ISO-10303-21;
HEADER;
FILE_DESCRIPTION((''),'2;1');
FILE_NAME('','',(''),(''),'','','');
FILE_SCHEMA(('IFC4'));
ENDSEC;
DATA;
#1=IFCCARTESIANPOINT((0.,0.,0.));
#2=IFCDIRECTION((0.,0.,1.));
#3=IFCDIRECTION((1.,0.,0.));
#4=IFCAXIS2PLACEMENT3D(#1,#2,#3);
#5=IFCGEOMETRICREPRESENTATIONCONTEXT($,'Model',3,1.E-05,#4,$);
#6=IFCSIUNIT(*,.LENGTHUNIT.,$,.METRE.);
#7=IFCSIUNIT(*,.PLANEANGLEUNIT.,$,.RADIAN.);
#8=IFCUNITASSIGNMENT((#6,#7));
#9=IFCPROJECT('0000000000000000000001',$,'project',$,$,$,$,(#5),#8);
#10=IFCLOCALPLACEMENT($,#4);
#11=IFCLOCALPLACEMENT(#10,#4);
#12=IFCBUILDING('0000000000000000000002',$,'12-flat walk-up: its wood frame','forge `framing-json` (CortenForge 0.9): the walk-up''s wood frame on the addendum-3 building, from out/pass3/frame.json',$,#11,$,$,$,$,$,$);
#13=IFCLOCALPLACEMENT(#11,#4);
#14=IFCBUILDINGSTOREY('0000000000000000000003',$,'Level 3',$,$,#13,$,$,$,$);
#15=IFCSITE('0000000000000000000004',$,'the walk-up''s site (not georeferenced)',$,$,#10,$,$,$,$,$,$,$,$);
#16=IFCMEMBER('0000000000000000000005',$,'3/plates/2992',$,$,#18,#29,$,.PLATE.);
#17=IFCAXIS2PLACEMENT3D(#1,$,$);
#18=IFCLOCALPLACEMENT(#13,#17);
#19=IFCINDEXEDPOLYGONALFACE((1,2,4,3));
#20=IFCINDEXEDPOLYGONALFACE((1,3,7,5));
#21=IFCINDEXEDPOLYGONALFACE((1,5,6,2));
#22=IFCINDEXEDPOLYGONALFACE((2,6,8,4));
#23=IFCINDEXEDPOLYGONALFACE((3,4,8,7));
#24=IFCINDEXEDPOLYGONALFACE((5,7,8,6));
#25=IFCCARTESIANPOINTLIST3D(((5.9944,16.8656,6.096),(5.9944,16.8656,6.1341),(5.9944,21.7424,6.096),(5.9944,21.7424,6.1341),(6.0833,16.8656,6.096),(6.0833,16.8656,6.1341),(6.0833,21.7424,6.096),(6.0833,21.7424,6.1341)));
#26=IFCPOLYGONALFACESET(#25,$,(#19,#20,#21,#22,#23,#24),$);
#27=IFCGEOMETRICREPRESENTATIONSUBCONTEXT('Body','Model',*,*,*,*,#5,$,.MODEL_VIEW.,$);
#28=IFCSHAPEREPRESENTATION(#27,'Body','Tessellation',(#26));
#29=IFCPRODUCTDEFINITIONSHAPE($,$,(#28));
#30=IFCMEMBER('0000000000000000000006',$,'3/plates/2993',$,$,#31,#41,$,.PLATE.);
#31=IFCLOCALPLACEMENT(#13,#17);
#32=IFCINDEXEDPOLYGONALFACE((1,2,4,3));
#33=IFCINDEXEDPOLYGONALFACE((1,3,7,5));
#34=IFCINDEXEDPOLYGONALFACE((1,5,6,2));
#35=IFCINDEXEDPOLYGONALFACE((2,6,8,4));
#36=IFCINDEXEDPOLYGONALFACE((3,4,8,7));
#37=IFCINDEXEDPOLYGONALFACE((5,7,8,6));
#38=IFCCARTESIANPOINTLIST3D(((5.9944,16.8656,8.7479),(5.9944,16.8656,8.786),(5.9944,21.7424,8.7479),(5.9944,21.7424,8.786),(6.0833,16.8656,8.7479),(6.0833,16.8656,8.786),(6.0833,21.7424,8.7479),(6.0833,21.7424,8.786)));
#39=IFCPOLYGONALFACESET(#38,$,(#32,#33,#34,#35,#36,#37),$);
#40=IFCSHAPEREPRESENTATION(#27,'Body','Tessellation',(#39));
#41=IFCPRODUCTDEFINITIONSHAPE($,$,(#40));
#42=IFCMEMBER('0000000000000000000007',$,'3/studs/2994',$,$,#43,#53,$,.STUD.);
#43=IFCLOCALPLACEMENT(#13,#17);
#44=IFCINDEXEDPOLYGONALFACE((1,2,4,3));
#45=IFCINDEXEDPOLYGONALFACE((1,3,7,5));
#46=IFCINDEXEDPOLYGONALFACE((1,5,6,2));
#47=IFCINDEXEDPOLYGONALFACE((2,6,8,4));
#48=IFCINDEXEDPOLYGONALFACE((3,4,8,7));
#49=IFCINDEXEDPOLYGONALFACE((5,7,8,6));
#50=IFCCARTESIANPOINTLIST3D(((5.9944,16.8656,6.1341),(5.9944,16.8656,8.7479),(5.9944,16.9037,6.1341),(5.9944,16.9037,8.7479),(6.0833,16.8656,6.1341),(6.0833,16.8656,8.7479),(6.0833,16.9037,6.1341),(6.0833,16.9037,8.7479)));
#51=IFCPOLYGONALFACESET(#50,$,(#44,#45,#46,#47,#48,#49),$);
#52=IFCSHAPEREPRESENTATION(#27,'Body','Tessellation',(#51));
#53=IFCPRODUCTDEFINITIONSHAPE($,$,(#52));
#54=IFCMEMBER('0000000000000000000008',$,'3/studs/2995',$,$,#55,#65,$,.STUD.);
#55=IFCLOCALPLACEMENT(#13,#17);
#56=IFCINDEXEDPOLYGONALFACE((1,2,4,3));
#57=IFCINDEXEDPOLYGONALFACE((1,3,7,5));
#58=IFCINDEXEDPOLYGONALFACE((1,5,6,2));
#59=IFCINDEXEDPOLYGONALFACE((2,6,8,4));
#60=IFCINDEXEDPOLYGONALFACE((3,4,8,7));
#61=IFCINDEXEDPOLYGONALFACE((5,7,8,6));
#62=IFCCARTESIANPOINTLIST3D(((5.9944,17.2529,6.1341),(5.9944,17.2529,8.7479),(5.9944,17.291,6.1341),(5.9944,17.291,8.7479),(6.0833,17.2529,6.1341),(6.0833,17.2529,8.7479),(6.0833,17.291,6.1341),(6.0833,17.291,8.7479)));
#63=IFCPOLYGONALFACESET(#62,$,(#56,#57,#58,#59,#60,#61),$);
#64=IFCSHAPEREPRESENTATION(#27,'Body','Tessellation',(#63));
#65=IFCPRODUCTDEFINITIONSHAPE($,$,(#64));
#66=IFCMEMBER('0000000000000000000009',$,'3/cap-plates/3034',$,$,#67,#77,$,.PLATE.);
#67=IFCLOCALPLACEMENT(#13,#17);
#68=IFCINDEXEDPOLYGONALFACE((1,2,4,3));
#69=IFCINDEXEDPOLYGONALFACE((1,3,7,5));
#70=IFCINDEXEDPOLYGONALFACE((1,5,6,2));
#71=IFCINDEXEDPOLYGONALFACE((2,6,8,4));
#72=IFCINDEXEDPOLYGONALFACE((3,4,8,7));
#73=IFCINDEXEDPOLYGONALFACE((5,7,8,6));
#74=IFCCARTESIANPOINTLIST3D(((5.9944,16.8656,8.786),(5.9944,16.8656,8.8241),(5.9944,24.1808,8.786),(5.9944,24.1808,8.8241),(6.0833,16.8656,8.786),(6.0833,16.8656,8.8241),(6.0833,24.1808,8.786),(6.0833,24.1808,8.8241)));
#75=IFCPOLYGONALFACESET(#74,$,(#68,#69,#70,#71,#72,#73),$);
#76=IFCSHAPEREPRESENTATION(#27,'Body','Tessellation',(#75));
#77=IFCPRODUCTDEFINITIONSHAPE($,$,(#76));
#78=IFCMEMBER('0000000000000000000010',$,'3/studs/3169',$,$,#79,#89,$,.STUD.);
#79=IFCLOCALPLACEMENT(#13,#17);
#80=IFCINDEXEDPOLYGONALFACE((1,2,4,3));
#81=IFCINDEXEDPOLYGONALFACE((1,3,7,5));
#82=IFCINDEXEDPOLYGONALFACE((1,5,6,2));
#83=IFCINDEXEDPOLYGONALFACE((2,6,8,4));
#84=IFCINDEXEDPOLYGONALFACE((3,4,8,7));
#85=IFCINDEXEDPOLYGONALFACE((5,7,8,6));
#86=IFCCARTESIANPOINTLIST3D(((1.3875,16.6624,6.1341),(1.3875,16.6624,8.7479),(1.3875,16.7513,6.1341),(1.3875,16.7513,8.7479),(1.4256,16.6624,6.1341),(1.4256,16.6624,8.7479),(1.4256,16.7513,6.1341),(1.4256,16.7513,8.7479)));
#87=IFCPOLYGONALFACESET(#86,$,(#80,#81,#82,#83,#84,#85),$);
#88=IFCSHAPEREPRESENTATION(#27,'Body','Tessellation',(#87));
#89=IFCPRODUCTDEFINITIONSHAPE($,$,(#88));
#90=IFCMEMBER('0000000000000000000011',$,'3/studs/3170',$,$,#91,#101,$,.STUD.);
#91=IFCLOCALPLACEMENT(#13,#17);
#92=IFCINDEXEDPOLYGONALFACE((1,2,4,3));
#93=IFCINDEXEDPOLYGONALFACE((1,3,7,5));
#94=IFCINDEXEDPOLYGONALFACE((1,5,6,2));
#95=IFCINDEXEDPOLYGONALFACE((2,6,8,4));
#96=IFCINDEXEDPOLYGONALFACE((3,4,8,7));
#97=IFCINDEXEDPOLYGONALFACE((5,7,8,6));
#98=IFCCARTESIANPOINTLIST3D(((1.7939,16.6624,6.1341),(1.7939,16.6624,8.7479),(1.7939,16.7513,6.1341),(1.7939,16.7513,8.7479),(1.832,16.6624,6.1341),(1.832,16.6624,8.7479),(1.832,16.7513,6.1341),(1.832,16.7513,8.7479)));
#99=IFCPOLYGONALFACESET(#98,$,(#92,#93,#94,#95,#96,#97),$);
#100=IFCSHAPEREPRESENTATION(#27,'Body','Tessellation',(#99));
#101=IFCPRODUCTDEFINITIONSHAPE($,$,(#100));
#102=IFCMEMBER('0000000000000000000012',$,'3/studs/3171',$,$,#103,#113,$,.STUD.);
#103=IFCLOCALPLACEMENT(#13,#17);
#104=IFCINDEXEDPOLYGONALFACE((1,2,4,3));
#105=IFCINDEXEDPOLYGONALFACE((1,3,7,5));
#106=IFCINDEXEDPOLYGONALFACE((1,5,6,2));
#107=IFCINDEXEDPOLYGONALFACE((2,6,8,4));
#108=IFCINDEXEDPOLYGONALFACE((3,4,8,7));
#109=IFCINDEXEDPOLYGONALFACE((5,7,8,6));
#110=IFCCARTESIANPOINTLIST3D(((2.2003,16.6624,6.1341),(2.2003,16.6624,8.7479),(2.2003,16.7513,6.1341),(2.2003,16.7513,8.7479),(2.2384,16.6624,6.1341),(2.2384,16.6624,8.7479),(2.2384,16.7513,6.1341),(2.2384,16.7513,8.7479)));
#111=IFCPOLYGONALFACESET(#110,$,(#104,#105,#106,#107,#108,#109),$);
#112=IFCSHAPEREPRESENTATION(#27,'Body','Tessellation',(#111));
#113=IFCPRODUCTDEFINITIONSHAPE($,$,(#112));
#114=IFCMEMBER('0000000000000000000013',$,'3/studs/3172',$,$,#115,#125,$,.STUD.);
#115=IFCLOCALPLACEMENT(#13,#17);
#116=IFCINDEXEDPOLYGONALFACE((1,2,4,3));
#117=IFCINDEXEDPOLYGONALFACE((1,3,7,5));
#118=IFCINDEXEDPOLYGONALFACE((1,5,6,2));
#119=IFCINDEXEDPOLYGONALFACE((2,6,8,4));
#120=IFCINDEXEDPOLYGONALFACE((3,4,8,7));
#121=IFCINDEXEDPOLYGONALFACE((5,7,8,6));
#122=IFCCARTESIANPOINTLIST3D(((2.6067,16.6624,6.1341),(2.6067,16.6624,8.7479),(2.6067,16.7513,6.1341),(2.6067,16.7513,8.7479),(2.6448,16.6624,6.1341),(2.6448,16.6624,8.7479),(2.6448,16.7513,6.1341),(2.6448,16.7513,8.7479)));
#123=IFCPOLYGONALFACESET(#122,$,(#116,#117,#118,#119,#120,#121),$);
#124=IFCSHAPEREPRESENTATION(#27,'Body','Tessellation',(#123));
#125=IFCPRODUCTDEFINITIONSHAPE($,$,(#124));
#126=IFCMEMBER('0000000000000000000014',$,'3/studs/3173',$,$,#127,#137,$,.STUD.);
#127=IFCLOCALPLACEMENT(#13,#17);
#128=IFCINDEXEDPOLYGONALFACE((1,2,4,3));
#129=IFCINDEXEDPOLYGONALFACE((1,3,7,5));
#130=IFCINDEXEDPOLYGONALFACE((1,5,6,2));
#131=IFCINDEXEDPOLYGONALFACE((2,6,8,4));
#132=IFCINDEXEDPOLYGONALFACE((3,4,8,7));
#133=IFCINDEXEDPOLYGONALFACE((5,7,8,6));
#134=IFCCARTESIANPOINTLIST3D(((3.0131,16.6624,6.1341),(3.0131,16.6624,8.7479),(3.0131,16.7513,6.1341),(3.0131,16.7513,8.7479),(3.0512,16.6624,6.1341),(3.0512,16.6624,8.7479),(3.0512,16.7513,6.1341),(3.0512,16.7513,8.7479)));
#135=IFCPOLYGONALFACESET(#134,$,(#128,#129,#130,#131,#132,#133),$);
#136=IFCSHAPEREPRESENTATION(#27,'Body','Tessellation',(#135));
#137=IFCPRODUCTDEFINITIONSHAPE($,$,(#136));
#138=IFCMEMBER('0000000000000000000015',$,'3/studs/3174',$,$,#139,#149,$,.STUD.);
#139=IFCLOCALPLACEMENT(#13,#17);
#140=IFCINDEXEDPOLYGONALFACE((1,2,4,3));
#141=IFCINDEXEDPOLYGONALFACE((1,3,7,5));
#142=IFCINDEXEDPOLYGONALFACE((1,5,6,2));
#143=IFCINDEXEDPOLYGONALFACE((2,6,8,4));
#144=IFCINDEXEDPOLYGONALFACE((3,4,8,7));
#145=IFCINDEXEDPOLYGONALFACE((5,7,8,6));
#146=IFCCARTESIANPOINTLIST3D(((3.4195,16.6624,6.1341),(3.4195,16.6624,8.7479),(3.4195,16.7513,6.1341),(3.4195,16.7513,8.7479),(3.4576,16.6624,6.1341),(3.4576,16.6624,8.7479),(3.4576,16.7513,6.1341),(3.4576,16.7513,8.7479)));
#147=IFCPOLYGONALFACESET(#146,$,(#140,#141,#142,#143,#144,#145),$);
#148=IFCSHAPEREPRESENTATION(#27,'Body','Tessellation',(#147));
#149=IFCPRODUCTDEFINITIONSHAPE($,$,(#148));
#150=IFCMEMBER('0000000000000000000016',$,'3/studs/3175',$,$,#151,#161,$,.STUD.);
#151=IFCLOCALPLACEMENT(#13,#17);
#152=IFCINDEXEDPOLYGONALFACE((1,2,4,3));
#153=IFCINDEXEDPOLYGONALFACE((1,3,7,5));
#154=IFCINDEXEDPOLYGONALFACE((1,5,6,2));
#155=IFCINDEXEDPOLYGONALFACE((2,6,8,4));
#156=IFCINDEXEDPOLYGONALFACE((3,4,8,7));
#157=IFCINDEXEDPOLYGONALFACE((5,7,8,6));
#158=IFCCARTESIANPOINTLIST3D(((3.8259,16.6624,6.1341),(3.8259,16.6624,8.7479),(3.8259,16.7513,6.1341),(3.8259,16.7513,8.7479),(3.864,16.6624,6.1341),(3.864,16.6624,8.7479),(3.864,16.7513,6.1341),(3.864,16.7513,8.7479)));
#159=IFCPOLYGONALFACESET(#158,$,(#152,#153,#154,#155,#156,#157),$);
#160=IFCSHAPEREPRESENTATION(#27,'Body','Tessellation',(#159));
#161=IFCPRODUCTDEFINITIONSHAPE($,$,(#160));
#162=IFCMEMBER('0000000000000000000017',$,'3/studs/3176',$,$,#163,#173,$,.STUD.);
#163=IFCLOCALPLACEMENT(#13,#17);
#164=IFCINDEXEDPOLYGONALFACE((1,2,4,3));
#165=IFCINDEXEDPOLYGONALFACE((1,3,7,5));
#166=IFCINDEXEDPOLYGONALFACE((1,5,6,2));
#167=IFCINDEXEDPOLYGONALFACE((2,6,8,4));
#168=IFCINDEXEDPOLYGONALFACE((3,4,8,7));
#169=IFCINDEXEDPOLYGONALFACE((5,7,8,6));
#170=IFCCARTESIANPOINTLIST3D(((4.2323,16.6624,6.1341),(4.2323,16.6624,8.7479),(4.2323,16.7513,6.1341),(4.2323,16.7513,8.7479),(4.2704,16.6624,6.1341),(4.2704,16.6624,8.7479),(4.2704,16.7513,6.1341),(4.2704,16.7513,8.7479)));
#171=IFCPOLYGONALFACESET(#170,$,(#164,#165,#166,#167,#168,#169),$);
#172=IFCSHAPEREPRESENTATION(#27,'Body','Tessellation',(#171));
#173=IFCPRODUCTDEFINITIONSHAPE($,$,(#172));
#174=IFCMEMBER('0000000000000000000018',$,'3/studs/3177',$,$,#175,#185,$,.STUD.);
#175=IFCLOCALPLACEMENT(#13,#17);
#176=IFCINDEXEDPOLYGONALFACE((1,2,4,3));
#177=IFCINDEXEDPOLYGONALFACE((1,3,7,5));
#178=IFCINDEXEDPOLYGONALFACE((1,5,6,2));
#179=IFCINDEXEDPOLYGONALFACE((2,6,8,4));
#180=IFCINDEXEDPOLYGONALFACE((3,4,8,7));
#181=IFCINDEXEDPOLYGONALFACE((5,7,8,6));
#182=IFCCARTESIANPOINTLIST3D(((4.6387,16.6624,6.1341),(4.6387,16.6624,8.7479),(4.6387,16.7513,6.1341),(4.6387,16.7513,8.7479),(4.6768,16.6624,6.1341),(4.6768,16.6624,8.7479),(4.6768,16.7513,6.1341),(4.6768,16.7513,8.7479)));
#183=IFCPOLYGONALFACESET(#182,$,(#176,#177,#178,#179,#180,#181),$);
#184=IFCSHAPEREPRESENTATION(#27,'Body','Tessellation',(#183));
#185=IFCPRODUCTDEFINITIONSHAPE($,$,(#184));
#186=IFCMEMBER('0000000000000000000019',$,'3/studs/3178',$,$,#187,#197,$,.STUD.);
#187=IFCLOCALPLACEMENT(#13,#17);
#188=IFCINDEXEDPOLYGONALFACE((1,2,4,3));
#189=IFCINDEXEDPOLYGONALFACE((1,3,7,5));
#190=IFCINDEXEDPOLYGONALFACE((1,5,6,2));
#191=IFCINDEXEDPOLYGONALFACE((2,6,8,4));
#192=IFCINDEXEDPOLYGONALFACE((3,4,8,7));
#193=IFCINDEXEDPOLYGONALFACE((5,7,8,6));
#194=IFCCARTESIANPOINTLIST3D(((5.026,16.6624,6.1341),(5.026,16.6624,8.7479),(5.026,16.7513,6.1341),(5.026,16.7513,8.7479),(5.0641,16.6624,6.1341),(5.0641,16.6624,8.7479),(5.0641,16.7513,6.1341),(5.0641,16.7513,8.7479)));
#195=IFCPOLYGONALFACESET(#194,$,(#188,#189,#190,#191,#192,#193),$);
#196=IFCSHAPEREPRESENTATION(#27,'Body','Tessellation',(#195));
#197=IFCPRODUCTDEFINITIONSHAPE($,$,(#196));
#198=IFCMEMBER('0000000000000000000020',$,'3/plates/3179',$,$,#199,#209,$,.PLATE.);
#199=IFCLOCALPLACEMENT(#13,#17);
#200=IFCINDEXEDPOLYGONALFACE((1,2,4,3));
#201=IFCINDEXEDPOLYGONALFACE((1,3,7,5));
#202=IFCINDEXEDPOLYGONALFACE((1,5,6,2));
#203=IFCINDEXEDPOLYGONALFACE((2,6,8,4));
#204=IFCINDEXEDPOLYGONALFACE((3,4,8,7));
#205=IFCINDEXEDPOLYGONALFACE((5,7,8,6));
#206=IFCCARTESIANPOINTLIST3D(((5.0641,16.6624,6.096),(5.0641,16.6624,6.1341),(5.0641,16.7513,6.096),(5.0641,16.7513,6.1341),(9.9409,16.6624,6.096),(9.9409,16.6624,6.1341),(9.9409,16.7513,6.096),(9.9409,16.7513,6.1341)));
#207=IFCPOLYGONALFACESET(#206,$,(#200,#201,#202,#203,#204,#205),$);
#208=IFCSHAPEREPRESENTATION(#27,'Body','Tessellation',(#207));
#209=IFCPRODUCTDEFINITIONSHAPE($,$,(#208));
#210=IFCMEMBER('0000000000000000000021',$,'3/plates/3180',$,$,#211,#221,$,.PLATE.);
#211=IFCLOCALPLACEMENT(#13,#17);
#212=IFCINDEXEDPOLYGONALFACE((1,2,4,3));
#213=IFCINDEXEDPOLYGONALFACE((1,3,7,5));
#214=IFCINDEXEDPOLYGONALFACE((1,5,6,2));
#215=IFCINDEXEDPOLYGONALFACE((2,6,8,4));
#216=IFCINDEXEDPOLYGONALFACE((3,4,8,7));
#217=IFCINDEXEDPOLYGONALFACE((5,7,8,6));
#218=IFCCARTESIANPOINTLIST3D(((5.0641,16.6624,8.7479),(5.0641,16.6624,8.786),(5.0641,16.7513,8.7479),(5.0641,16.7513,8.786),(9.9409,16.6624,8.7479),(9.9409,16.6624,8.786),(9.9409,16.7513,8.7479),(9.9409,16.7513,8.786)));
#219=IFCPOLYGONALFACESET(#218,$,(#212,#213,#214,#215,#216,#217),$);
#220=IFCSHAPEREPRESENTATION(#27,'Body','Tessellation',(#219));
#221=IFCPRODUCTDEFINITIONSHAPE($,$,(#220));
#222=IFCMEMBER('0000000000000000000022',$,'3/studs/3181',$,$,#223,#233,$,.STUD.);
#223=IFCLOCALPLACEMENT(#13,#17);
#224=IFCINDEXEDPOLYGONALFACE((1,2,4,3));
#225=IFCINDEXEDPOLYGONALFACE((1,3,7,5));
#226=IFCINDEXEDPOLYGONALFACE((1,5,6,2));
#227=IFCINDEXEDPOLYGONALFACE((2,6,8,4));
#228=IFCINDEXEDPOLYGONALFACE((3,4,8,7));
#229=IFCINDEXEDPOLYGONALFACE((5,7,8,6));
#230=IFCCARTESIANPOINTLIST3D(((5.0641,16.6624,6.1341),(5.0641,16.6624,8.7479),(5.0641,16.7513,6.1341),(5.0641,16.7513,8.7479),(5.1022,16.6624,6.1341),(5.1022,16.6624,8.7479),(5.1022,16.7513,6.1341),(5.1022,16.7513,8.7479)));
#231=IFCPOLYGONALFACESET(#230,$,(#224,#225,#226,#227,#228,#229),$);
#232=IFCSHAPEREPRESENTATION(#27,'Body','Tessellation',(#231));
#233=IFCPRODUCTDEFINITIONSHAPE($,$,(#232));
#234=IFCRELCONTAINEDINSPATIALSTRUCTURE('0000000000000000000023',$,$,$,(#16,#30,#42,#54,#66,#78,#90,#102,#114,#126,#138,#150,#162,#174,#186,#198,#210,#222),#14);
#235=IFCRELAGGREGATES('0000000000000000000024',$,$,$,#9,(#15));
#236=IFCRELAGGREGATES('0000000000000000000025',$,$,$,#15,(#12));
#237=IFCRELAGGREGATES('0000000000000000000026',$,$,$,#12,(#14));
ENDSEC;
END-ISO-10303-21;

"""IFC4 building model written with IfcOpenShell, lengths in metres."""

from ifc_helpers import new_model, si_unit, frame, frame_2d, origin, origin_with_axes, place, context, subcontext, project, spatial, rectangle, extrude, element, save


model = new_model("IFC4")

# Units and contexts
model_context = context("Model", 3, precision=1e-05, world=origin_with_axes())
body_context = subcontext(model_context, "Body", "Model", "MODEL_VIEW")
ifc_project = project(units=[si_unit("LENGTHUNIT", "METRE"), si_unit("PLANEANGLEUNIT", "RADIAN")], contexts=[model_context])

# Site, building, storey
site_placement = place(None, origin_with_axes())
site = spatial("IfcSite", under=ifc_project, at=site_placement, Name="the walk-up's site (not georeferenced)")
building_placement = place(site_placement, origin_with_axes())
building = spatial("IfcBuilding", under=site, at=building_placement, Name="12-flat walk-up: its wood frame", Description="forge `framing-json` (CortenForge 0.9): the walk-up's wood frame on the addendum-3 building, from out/pass3/frame.json")
storey_placement = place(building_placement, origin_with_axes())
storey = spatial("IfcBuildingStorey", under=building, at=storey_placement, Name="Level 3")

# Members
for number, where, z_axis, x_axis, name in (
    (1, (5.9944, 16.8656, 6.096), (0.0, 0.0, 1.0), (1.0, 0.0, 0.0), "3/plates/2992"),
    (2, (5.9944, 16.8656, 8.7479), (0.0, 0.0, 1.0), (1.0, 0.0, 0.0), "3/plates/2993"),
):
    element("IfcMember", number, at=place(storey_placement, frame(where, z_axis=z_axis, x_axis=x_axis)), inside=storey, Name=name, PredefinedType="PLATE", context=body_context, shape_type="SweptSolid", body=[
        extrude(rectangle(XDim=0.0889, YDim=4.8768, at=frame_2d((0.0445, 2.4384))), origin(), (0.0, 0.0, 1.0), 0.0381),
    ])
for number, where, z_axis, x_axis, name in (
    (3, (5.9944, 16.8656, 6.1341), (0.0, 0.0, 1.0), (1.0, 0.0, 0.0), "3/studs/2994"),
    (4, (5.9944, 17.2529, 6.1341), (0.0, 0.0, 1.0), (1.0, 0.0, 0.0), "3/studs/2995"),
):
    element("IfcMember", number, at=place(storey_placement, frame(where, z_axis=z_axis, x_axis=x_axis)), inside=storey, Name=name, PredefinedType="STUD", context=body_context, shape_type="SweptSolid", body=[
        extrude(rectangle(XDim=0.0889, YDim=0.0381, at=frame_2d((0.0445, 0.0191))), origin(), (0.0, 0.0, 1.0), 2.6138),
    ])
member_1_placement = place(storey_placement, frame((5.9944, 16.8656, 8.786), z_axis=(0.0, 0.0, 1.0), x_axis=(1.0, 0.0, 0.0)))
element("IfcMember", 5, at=member_1_placement, inside=storey, Name="3/cap-plates/3034", PredefinedType="PLATE", context=body_context, shape_type="SweptSolid", body=[
    extrude(rectangle(XDim=0.0889, YDim=7.3152, at=frame_2d((0.0445, 3.6576))), origin(), (0.0, 0.0, 1.0), 0.0381),
])
member_2_placement = place(storey_placement, frame((1.3875, 16.6624, 6.1341), z_axis=(0.0, 0.0, 1.0), x_axis=(1.0, 0.0, 0.0)))
element("IfcMember", 6, at=member_2_placement, inside=storey, Name="3/studs/3169", PredefinedType="STUD", context=body_context, shape_type="SweptSolid", body=[
    extrude(rectangle(XDim=0.0381, YDim=0.0889, at=frame_2d((0.0191, 0.0444))), origin(), (0.0, 0.0, 1.0), 2.6138),
])
member_3_placement = place(storey_placement, frame((1.7939, 16.6624, 6.1341), z_axis=(0.0, 0.0, 1.0), x_axis=(1.0, 0.0, 0.0)))
element("IfcMember", 7, at=member_3_placement, inside=storey, Name="3/studs/3170", PredefinedType="STUD", context=body_context, shape_type="SweptSolid", body=[
    extrude(rectangle(XDim=0.0381, YDim=0.0889, at=frame_2d((0.019, 0.0444))), origin(), (0.0, 0.0, 1.0), 2.6138),
])
for number, where, z_axis, x_axis, name in (
    (8, (2.2003, 16.6624, 6.1341), (0.0, 0.0, 1.0), (1.0, 0.0, 0.0), "3/studs/3171"),
    (9, (2.6067, 16.6624, 6.1341), (0.0, 0.0, 1.0), (1.0, 0.0, 0.0), "3/studs/3172"),
    (10, (3.0131, 16.6624, 6.1341), (0.0, 0.0, 1.0), (1.0, 0.0, 0.0), "3/studs/3173"),
    (11, (3.4195, 16.6624, 6.1341), (0.0, 0.0, 1.0), (1.0, 0.0, 0.0), "3/studs/3174"),
    (12, (3.8259, 16.6624, 6.1341), (0.0, 0.0, 1.0), (1.0, 0.0, 0.0), "3/studs/3175"),
    (13, (4.2323, 16.6624, 6.1341), (0.0, 0.0, 1.0), (1.0, 0.0, 0.0), "3/studs/3176"),
    (14, (4.6387, 16.6624, 6.1341), (0.0, 0.0, 1.0), (1.0, 0.0, 0.0), "3/studs/3177"),
    (15, (5.026, 16.6624, 6.1341), (0.0, 0.0, 1.0), (1.0, 0.0, 0.0), "3/studs/3178"),
):
    element("IfcMember", number, at=place(storey_placement, frame(where, z_axis=z_axis, x_axis=x_axis)), inside=storey, Name=name, PredefinedType="STUD", context=body_context, shape_type="SweptSolid", body=[
        extrude(rectangle(XDim=0.0381, YDim=0.0889, at=frame_2d((0.0191, 0.0444))), origin(), (0.0, 0.0, 1.0), 2.6138),
    ])
for number, where, z_axis, x_axis, name in (
    (16, (5.0641, 16.6624, 6.096), (0.0, 0.0, 1.0), (1.0, 0.0, 0.0), "3/plates/3179"),
    (17, (5.0641, 16.6624, 8.7479), (0.0, 0.0, 1.0), (1.0, 0.0, 0.0), "3/plates/3180"),
):
    element("IfcMember", number, at=place(storey_placement, frame(where, z_axis=z_axis, x_axis=x_axis)), inside=storey, Name=name, PredefinedType="PLATE", context=body_context, shape_type="SweptSolid", body=[
        extrude(rectangle(XDim=4.8768, YDim=0.0889, at=frame_2d((2.4384, 0.0444))), origin(), (0.0, 0.0, 1.0), 0.0381),
    ])
for number, where, z_axis, x_axis, name in (
    (18, (5.0641, 16.6624, 6.1341), (0.0, 0.0, 1.0), (1.0, 0.0, 0.0), "3/studs/3181"),
):
    element("IfcMember", number, at=place(storey_placement, frame(where, z_axis=z_axis, x_axis=x_axis)), inside=storey, Name=name, PredefinedType="STUD", context=body_context, shape_type="SweptSolid", body=[
        extrude(rectangle(XDim=0.0381, YDim=0.0889, at=frame_2d((0.0191, 0.0444))), origin(), (0.0, 0.0, 1.0), 2.6138),
    ])

save(model, "model.ifc")
